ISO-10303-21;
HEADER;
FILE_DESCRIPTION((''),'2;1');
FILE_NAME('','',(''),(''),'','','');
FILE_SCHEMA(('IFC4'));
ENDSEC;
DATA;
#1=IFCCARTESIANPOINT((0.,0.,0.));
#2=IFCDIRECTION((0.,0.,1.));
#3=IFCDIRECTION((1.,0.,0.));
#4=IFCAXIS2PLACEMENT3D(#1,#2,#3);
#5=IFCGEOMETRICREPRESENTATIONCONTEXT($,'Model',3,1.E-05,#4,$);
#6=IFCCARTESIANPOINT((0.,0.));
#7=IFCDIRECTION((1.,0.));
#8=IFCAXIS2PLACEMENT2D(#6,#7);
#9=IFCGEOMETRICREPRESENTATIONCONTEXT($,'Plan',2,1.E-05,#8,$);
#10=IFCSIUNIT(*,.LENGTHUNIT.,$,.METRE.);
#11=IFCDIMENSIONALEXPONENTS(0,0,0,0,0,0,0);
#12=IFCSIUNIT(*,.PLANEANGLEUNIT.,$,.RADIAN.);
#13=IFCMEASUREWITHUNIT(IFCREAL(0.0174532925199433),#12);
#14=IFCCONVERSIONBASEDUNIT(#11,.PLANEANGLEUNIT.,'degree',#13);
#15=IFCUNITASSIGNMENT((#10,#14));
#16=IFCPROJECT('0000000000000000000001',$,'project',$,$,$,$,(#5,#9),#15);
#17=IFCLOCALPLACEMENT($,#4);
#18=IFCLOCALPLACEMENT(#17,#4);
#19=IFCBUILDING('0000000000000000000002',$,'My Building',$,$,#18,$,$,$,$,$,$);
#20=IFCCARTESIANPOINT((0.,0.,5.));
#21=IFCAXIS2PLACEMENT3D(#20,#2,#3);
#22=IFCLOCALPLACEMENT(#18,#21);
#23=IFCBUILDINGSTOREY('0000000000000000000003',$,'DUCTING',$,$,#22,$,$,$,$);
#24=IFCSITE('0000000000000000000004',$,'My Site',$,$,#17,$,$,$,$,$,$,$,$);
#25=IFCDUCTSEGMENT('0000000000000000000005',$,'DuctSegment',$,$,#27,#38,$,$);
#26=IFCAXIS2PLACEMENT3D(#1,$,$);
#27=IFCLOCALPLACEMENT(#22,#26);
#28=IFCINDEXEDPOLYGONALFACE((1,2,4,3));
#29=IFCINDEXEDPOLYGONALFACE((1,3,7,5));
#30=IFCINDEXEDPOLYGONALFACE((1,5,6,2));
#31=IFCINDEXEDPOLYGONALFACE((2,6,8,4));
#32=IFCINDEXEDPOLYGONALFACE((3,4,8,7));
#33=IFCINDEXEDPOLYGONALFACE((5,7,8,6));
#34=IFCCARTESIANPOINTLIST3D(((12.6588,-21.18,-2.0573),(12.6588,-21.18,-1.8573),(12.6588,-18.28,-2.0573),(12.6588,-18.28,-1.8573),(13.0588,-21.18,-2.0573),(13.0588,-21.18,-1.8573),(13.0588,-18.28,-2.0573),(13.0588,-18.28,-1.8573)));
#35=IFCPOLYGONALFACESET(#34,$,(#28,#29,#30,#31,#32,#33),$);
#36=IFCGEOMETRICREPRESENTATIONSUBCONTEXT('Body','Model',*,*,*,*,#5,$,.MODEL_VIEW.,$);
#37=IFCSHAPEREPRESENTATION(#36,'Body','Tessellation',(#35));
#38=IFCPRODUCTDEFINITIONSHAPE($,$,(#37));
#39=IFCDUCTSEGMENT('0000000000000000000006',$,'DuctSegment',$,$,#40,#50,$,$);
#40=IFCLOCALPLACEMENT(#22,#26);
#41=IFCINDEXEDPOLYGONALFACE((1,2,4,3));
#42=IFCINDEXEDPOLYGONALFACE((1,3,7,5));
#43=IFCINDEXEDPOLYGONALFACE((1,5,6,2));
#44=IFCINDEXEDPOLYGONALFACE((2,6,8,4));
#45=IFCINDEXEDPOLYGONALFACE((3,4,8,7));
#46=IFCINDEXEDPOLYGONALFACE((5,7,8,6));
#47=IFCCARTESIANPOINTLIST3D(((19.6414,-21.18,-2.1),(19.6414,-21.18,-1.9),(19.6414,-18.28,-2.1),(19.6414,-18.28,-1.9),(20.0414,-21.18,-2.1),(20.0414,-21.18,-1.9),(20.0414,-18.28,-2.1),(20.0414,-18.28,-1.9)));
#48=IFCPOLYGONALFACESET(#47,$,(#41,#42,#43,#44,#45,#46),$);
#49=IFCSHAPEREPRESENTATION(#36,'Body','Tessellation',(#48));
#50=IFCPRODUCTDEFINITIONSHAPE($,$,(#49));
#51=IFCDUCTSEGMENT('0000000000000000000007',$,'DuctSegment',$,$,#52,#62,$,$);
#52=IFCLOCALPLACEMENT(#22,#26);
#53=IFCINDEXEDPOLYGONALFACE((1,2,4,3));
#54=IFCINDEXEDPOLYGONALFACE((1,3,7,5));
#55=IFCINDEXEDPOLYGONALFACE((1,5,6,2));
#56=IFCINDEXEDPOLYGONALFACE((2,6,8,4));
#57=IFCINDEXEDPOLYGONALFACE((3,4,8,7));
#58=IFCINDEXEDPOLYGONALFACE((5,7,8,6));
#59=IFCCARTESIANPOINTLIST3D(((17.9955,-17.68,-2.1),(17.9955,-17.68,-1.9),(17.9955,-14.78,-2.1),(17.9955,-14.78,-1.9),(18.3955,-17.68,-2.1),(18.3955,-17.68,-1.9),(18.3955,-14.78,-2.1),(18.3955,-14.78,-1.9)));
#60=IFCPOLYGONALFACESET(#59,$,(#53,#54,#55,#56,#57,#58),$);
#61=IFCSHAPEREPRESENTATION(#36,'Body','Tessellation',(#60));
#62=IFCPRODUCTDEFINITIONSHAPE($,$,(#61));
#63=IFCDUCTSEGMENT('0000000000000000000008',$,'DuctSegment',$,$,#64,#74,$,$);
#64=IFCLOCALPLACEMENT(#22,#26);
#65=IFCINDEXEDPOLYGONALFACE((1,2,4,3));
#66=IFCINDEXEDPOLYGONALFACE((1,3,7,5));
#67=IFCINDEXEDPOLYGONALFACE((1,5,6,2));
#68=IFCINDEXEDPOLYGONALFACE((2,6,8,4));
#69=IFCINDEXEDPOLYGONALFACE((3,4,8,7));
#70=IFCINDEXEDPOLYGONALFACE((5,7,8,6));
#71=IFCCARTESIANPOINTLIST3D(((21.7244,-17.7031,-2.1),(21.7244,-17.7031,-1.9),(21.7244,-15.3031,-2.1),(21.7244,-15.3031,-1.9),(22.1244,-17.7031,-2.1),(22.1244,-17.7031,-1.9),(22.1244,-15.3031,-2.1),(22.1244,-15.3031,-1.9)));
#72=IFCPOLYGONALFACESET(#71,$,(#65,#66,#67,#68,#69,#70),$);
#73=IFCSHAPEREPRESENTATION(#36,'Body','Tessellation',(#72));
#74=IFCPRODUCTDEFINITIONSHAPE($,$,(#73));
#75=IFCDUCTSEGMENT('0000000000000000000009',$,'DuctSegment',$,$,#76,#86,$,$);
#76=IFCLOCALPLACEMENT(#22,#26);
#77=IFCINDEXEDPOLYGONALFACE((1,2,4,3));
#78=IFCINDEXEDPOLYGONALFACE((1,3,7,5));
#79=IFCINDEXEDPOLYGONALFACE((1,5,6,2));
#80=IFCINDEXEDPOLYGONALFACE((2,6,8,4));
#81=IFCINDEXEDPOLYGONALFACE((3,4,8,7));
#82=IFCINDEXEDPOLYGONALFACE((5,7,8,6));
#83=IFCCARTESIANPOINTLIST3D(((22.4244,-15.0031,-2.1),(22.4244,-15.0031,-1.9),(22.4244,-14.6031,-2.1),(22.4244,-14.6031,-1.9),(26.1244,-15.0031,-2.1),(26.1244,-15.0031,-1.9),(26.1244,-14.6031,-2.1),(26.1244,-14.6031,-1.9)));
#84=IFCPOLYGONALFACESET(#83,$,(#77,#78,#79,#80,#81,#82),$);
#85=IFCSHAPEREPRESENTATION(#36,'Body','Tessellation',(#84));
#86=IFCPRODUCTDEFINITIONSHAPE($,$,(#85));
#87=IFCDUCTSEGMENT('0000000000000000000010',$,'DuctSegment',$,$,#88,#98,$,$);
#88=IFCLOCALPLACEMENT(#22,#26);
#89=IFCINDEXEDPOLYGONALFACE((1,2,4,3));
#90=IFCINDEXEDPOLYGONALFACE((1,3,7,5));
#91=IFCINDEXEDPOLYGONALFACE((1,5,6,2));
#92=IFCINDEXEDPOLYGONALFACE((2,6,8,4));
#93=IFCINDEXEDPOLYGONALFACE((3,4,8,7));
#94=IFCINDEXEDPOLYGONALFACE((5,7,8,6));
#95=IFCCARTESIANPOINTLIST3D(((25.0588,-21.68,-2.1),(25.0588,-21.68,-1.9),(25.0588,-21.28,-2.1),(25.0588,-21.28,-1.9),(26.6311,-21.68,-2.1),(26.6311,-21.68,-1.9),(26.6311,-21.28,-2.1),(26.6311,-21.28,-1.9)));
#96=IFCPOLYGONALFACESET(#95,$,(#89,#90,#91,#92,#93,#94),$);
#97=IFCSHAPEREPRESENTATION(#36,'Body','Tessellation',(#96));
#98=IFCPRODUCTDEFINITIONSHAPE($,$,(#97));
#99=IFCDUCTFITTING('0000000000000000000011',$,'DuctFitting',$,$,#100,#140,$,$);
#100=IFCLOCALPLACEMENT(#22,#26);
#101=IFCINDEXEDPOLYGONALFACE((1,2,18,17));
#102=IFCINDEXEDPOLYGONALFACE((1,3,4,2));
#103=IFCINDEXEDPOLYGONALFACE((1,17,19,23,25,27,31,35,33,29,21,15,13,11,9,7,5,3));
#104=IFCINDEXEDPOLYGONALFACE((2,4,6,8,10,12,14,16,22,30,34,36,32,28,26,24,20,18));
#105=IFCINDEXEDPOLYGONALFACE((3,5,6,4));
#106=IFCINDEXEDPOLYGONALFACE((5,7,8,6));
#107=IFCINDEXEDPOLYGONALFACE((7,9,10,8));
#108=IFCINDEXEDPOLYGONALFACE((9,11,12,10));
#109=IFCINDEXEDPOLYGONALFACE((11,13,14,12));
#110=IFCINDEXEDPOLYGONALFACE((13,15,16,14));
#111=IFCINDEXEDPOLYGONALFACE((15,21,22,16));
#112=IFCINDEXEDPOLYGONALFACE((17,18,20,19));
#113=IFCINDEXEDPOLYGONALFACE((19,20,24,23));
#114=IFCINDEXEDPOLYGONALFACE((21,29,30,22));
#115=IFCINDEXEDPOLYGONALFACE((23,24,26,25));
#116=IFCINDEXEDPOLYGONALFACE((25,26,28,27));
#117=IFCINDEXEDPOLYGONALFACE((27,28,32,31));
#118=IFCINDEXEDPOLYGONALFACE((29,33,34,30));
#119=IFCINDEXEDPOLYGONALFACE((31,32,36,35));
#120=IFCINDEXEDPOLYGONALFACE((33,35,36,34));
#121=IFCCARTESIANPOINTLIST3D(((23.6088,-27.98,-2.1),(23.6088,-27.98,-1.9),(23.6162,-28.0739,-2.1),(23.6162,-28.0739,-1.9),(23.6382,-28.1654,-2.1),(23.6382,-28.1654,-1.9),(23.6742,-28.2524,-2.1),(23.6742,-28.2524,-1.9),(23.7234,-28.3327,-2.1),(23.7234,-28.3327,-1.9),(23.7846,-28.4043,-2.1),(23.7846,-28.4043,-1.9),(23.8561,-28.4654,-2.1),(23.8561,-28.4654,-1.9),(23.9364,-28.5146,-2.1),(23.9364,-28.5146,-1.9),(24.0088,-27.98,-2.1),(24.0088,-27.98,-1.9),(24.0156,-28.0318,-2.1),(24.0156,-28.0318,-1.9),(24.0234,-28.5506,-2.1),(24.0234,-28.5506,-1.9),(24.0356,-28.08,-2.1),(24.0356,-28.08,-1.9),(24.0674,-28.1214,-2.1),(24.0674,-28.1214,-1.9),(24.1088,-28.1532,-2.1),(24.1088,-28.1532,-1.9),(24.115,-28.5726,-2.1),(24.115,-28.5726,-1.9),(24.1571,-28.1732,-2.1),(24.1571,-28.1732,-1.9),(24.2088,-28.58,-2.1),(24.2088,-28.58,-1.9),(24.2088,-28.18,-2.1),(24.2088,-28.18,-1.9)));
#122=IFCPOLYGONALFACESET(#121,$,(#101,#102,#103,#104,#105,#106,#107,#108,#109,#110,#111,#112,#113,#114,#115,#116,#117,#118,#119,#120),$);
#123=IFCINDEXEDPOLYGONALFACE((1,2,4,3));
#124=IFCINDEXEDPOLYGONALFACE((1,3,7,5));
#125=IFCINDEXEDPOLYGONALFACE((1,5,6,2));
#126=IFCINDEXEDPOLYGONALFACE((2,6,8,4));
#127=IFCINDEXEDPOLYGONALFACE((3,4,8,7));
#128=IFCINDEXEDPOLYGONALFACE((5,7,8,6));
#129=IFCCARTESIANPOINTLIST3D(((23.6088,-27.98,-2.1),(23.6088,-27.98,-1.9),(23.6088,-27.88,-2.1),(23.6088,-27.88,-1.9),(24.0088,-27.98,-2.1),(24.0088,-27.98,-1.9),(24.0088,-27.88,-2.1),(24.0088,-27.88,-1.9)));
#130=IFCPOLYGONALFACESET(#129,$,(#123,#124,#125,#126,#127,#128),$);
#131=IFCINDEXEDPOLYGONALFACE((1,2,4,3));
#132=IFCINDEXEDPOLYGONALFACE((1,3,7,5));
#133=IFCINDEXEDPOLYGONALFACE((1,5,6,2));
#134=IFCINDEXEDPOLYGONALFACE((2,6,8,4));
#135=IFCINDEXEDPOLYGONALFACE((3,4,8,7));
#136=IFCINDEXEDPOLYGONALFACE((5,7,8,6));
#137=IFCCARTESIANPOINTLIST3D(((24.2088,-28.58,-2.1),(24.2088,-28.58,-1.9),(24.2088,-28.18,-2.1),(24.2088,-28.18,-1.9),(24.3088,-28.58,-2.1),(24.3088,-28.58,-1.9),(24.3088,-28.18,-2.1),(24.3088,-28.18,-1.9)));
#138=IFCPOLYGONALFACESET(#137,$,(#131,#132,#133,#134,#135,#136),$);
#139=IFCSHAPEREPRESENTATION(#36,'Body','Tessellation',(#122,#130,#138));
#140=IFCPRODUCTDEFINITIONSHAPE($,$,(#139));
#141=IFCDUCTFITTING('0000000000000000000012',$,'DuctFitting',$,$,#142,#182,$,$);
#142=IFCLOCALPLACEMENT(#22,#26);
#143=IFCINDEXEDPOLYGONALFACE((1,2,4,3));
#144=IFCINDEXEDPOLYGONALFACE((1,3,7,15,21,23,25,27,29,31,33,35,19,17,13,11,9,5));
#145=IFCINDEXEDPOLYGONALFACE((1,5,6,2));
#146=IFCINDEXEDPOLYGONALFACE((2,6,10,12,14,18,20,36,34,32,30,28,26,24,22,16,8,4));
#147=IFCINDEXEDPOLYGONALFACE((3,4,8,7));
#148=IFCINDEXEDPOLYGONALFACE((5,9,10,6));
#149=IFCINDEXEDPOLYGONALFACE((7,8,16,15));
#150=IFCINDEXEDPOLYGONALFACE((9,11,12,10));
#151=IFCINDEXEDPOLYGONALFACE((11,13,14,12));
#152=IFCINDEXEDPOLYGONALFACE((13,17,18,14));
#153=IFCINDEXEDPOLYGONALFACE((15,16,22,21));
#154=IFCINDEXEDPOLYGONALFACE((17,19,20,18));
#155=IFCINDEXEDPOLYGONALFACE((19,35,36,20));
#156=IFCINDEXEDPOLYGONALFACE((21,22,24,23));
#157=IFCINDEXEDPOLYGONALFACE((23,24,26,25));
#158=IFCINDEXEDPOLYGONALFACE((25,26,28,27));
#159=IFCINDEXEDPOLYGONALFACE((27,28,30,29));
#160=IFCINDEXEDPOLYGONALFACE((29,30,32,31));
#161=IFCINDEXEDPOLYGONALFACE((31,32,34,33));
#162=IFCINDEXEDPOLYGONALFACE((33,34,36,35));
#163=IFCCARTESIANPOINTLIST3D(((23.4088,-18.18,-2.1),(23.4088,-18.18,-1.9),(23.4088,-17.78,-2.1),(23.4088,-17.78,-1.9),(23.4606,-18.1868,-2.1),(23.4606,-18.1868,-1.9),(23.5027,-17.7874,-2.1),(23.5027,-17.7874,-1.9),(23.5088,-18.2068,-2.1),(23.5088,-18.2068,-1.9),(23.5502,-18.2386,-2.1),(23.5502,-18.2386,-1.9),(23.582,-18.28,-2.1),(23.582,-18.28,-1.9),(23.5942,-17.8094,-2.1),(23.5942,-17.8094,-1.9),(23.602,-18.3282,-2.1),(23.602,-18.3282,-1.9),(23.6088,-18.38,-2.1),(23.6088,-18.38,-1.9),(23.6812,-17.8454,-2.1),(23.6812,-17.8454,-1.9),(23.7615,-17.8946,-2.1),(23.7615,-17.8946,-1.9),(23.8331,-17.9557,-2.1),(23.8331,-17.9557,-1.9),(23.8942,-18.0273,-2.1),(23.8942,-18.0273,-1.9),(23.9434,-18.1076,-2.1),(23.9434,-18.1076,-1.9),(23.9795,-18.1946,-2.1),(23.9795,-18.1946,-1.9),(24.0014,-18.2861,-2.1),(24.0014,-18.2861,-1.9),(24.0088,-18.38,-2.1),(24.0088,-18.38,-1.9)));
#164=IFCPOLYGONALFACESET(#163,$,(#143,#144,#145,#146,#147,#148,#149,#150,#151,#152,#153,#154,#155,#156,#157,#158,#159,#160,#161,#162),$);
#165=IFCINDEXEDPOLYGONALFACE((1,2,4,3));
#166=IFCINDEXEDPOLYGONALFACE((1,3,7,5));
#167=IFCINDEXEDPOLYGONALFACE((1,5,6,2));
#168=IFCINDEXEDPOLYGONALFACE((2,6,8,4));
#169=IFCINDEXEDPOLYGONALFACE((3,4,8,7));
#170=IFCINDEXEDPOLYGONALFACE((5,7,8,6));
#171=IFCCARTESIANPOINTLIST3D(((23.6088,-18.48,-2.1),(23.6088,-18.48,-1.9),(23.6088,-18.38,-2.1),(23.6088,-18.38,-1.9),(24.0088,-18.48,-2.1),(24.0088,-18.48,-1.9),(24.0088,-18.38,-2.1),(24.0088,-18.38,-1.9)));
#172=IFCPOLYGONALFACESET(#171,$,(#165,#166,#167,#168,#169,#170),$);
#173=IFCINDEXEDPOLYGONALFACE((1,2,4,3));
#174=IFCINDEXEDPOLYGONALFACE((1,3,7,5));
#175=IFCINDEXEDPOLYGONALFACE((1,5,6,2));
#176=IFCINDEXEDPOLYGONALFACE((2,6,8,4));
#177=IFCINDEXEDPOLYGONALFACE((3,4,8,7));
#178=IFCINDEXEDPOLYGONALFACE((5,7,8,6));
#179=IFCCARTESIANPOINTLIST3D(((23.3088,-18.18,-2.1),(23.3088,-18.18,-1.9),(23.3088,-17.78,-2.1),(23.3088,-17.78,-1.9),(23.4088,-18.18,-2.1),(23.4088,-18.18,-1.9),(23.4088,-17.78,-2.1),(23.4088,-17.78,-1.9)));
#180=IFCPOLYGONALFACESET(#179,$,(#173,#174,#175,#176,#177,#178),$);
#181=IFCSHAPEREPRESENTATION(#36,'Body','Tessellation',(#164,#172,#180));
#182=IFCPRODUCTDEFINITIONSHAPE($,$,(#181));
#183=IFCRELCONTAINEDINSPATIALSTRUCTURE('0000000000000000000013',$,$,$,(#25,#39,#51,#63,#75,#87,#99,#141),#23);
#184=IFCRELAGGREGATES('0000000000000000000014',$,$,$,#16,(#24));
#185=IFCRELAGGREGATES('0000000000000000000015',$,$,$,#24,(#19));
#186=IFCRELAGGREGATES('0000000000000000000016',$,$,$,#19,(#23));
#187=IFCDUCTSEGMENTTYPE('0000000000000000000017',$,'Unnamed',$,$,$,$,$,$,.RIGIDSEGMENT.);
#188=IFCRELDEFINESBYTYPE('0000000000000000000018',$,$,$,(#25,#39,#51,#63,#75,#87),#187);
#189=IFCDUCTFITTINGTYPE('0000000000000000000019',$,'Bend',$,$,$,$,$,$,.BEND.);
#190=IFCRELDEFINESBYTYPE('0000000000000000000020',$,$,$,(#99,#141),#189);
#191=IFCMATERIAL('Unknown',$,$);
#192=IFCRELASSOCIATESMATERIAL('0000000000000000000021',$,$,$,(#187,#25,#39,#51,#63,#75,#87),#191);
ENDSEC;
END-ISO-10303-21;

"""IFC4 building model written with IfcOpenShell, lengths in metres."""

from ifc_helpers import new_model, entity, si_unit, converted_unit, frame, origin_with_axes, origin_2d_with_axis, place, context, subcontext, project, spatial, line, arc, indexed_curve, rectangle, outline, extrude, source, transform, mapped, material, material_profile, profile_set, profile_usage, type_object, type_shapes, element, save


model = new_model("IFC4")

# Units and contexts
model_context = context("Model", 3, precision=1e-05, world=origin_with_axes())
plan_context = context("Plan", 2, precision=1e-05, world=origin_2d_with_axis())
body_context = subcontext(model_context, "Body", "Model", "MODEL_VIEW")
ifc_project = project(units=[si_unit("LENGTHUNIT", "METRE"), converted_unit("PLANEANGLEUNIT", "degree", entity("IfcReal", 0.0174532925199433), si_unit("PLANEANGLEUNIT", "RADIAN"), dimensions=[0, 0, 0, 0, 0, 0, 0])], contexts=[model_context, plan_context])

# Site, building, storey
site_placement = place(None, origin_with_axes())
site = spatial("IfcSite", under=ifc_project, at=site_placement, Name="My Site")
building_placement = place(site_placement, origin_with_axes())
building = spatial("IfcBuilding", under=site, at=building_placement, Name="My Building")
storey_placement = place(building_placement, frame((0.0, 0.0, 5.0), z_axis=(0.0, 0.0, 1.0), x_axis=(1.0, 0.0, 0.0)))
storey = spatial("IfcBuildingStorey", under=building, at=storey_placement, Name="DUCTING")

# Duct segments
ifc_material = material(Name="Unknown")
ifc_material_profile_1 = material_profile(ifc_material, rectangle(XDim=0.4, YDim=0.2))
ifc_profile_set_1 = profile_set([ifc_material_profile_1])
duct_segment_type = type_object("IfcDuctSegmentType", Name="Unnamed", PredefinedType="RIGIDSEGMENT", material=ifc_profile_set_1)
ifc_profile_usage_1 = profile_usage(ifc_profile_set_1, cardinal=5)
duct_segment_1_placement = place(storey_placement, frame((12.8588, -21.18, -1.9573), z_axis=(0.0, 1.0, 0.000001), x_axis=(-1.0, 0.0, 0.0)))
element("IfcDuctSegment", 1, at=duct_segment_1_placement, inside=storey, type_object=duct_segment_type, material=ifc_profile_usage_1, Name="DuctSegment", context=body_context, shape_type="SweptSolid", body=[
    extrude(rectangle(XDim=0.4, YDim=0.2), origin_with_axes(), (0.0, 0.0, 1.0), 2.9),
])
ifc_profile_usage_2 = profile_usage(ifc_profile_set_1, cardinal=5)
duct_segment_2_placement = place(storey_placement, frame((19.8414, -21.18, -2.0), z_axis=(0.0, 1.0, 0.000001), x_axis=(-1.0, 0.0, 0.0)))
element("IfcDuctSegment", 2, at=duct_segment_2_placement, inside=storey, type_object=duct_segment_type, material=ifc_profile_usage_2, Name="DuctSegment", context=body_context, shape_type="SweptSolid", body=[
    extrude(rectangle(XDim=0.4, YDim=0.2), origin_with_axes(), (0.0, 0.0, 1.0), 2.9),
])
ifc_profile_usage_3 = profile_usage(ifc_profile_set_1, cardinal=5)
duct_segment_3_placement = place(storey_placement, frame((18.1955, -17.68, -2.0), z_axis=(0.0, 1.0, 0.000001), x_axis=(-1.0, 0.0, 0.0)))
element("IfcDuctSegment", 3, at=duct_segment_3_placement, inside=storey, type_object=duct_segment_type, material=ifc_profile_usage_3, Name="DuctSegment", context=body_context, shape_type="SweptSolid", body=[
    extrude(rectangle(XDim=0.4, YDim=0.2), origin_with_axes(), (0.0, 0.0, 1.0), 2.9),
])
ifc_profile_usage_4 = profile_usage(ifc_profile_set_1, cardinal=5)
duct_segment_4_placement = place(storey_placement, frame((21.9244, -17.7031, -2.0), z_axis=(0.0, 1.0, 0.000001), x_axis=(-1.0, 0.0, 0.0)))
element("IfcDuctSegment", 4, at=duct_segment_4_placement, inside=storey, type_object=duct_segment_type, material=ifc_profile_usage_4, Name="DuctSegment", context=body_context, shape_type="SweptSolid", body=[
    extrude(rectangle(XDim=0.4, YDim=0.2), origin_with_axes(), (0.0, 0.0, 1.0), 2.4),
])
ifc_profile_usage_5 = profile_usage(ifc_profile_set_1, cardinal=5)
duct_segment_5_placement = place(storey_placement, frame((22.4244, -14.8031, -2.0), z_axis=(1.0, 0.0, 0.0), x_axis=(0.0, 1.0, 0.0)))
element("IfcDuctSegment", 5, at=duct_segment_5_placement, inside=storey, type_object=duct_segment_type, material=ifc_profile_usage_5, Name="DuctSegment", context=body_context, shape_type="SweptSolid", body=[
    extrude(rectangle(XDim=0.4, YDim=0.2), origin_with_axes(), (0.0, 0.0, 1.0), 3.7),
])
ifc_profile_usage_6 = profile_usage(ifc_profile_set_1, cardinal=5)
duct_segment_6_placement = place(storey_placement, frame((25.0588, -21.48, -2.0), z_axis=(1.0, 0.0, 0.0), x_axis=(0.0, 1.0, 0.0)))
element("IfcDuctSegment", 6, at=duct_segment_6_placement, inside=storey, type_object=duct_segment_type, material=ifc_profile_usage_6, Name="DuctSegment", context=body_context, shape_type="SweptSolid", body=[
    extrude(rectangle(XDim=0.4, YDim=0.2), origin_with_axes(), (0.0, 0.0, 1.0), 1.5723),
])

# Duct fittings
duct_fitting_type_1 = type_object("IfcDuctFittingType", Name="Bend", PredefinedType="BEND")
shared_shape = source(origin_with_axes(), body_context, "Body", "SweptSolid", [
    extrude(outline(indexed_curve([(0.2, 0.0), (0.2586, 0.1414), (0.4, 0.2), (0.4, 0.6), (-0.0243, 0.4243), (-0.2, 0.0)], segments=[arc(1, 2, 3), line(3, 4), arc(4, 5, 6), line(6, 1)])), frame((0.0, -0.1, 0.1), z_axis=(0.0, -1.0, 0.0), x_axis=(1.0, 0.0, 0.0)), (0.0, 0.0, -1.0), 0.2),
    extrude(rectangle(XDim=0.4, YDim=0.2), origin_with_axes(), (0.0, 0.0, 1.0), 0.1),
    extrude(rectangle(XDim=0.4, YDim=0.2), frame((0.4, 0.0, 0.5), z_axis=(1.0, 0.0, 0.000001), x_axis=(-0.000001, 0.0, 1.0)), (0.0, 0.0, 1.0), 0.1),
])
type_shapes(duct_fitting_type_1, [shared_shape])
for number, where, z_axis, x_axis, name in (
    (7, (23.8088, -27.88, -2.0), (0.0, -1.0, 0.000002), (1.0, 0.0, 0.0), "DuctFitting"),
    (8, (23.8088, -18.48, -2.0), (0.0, 1.0, 0.0), (-1.0, 0.0, 0.0), "DuctFitting"),
):
    element("IfcDuctFitting", number, at=place(storey_placement, frame(where, z_axis=z_axis, x_axis=x_axis)), inside=storey, type_object=duct_fitting_type_1, Name=name, context=body_context, shape_type="MappedRepresentation", body=[
        mapped(shared_shape, transform((0.0, 0.0, 0.0), x_axis=(1.0, 0.0, 0.0), y_axis=(0.0, 1.0, 0.0), z_axis=(0.0, 0.0, 1.0), scale=1.0)),
    ])

save(model, "model.ifc")
